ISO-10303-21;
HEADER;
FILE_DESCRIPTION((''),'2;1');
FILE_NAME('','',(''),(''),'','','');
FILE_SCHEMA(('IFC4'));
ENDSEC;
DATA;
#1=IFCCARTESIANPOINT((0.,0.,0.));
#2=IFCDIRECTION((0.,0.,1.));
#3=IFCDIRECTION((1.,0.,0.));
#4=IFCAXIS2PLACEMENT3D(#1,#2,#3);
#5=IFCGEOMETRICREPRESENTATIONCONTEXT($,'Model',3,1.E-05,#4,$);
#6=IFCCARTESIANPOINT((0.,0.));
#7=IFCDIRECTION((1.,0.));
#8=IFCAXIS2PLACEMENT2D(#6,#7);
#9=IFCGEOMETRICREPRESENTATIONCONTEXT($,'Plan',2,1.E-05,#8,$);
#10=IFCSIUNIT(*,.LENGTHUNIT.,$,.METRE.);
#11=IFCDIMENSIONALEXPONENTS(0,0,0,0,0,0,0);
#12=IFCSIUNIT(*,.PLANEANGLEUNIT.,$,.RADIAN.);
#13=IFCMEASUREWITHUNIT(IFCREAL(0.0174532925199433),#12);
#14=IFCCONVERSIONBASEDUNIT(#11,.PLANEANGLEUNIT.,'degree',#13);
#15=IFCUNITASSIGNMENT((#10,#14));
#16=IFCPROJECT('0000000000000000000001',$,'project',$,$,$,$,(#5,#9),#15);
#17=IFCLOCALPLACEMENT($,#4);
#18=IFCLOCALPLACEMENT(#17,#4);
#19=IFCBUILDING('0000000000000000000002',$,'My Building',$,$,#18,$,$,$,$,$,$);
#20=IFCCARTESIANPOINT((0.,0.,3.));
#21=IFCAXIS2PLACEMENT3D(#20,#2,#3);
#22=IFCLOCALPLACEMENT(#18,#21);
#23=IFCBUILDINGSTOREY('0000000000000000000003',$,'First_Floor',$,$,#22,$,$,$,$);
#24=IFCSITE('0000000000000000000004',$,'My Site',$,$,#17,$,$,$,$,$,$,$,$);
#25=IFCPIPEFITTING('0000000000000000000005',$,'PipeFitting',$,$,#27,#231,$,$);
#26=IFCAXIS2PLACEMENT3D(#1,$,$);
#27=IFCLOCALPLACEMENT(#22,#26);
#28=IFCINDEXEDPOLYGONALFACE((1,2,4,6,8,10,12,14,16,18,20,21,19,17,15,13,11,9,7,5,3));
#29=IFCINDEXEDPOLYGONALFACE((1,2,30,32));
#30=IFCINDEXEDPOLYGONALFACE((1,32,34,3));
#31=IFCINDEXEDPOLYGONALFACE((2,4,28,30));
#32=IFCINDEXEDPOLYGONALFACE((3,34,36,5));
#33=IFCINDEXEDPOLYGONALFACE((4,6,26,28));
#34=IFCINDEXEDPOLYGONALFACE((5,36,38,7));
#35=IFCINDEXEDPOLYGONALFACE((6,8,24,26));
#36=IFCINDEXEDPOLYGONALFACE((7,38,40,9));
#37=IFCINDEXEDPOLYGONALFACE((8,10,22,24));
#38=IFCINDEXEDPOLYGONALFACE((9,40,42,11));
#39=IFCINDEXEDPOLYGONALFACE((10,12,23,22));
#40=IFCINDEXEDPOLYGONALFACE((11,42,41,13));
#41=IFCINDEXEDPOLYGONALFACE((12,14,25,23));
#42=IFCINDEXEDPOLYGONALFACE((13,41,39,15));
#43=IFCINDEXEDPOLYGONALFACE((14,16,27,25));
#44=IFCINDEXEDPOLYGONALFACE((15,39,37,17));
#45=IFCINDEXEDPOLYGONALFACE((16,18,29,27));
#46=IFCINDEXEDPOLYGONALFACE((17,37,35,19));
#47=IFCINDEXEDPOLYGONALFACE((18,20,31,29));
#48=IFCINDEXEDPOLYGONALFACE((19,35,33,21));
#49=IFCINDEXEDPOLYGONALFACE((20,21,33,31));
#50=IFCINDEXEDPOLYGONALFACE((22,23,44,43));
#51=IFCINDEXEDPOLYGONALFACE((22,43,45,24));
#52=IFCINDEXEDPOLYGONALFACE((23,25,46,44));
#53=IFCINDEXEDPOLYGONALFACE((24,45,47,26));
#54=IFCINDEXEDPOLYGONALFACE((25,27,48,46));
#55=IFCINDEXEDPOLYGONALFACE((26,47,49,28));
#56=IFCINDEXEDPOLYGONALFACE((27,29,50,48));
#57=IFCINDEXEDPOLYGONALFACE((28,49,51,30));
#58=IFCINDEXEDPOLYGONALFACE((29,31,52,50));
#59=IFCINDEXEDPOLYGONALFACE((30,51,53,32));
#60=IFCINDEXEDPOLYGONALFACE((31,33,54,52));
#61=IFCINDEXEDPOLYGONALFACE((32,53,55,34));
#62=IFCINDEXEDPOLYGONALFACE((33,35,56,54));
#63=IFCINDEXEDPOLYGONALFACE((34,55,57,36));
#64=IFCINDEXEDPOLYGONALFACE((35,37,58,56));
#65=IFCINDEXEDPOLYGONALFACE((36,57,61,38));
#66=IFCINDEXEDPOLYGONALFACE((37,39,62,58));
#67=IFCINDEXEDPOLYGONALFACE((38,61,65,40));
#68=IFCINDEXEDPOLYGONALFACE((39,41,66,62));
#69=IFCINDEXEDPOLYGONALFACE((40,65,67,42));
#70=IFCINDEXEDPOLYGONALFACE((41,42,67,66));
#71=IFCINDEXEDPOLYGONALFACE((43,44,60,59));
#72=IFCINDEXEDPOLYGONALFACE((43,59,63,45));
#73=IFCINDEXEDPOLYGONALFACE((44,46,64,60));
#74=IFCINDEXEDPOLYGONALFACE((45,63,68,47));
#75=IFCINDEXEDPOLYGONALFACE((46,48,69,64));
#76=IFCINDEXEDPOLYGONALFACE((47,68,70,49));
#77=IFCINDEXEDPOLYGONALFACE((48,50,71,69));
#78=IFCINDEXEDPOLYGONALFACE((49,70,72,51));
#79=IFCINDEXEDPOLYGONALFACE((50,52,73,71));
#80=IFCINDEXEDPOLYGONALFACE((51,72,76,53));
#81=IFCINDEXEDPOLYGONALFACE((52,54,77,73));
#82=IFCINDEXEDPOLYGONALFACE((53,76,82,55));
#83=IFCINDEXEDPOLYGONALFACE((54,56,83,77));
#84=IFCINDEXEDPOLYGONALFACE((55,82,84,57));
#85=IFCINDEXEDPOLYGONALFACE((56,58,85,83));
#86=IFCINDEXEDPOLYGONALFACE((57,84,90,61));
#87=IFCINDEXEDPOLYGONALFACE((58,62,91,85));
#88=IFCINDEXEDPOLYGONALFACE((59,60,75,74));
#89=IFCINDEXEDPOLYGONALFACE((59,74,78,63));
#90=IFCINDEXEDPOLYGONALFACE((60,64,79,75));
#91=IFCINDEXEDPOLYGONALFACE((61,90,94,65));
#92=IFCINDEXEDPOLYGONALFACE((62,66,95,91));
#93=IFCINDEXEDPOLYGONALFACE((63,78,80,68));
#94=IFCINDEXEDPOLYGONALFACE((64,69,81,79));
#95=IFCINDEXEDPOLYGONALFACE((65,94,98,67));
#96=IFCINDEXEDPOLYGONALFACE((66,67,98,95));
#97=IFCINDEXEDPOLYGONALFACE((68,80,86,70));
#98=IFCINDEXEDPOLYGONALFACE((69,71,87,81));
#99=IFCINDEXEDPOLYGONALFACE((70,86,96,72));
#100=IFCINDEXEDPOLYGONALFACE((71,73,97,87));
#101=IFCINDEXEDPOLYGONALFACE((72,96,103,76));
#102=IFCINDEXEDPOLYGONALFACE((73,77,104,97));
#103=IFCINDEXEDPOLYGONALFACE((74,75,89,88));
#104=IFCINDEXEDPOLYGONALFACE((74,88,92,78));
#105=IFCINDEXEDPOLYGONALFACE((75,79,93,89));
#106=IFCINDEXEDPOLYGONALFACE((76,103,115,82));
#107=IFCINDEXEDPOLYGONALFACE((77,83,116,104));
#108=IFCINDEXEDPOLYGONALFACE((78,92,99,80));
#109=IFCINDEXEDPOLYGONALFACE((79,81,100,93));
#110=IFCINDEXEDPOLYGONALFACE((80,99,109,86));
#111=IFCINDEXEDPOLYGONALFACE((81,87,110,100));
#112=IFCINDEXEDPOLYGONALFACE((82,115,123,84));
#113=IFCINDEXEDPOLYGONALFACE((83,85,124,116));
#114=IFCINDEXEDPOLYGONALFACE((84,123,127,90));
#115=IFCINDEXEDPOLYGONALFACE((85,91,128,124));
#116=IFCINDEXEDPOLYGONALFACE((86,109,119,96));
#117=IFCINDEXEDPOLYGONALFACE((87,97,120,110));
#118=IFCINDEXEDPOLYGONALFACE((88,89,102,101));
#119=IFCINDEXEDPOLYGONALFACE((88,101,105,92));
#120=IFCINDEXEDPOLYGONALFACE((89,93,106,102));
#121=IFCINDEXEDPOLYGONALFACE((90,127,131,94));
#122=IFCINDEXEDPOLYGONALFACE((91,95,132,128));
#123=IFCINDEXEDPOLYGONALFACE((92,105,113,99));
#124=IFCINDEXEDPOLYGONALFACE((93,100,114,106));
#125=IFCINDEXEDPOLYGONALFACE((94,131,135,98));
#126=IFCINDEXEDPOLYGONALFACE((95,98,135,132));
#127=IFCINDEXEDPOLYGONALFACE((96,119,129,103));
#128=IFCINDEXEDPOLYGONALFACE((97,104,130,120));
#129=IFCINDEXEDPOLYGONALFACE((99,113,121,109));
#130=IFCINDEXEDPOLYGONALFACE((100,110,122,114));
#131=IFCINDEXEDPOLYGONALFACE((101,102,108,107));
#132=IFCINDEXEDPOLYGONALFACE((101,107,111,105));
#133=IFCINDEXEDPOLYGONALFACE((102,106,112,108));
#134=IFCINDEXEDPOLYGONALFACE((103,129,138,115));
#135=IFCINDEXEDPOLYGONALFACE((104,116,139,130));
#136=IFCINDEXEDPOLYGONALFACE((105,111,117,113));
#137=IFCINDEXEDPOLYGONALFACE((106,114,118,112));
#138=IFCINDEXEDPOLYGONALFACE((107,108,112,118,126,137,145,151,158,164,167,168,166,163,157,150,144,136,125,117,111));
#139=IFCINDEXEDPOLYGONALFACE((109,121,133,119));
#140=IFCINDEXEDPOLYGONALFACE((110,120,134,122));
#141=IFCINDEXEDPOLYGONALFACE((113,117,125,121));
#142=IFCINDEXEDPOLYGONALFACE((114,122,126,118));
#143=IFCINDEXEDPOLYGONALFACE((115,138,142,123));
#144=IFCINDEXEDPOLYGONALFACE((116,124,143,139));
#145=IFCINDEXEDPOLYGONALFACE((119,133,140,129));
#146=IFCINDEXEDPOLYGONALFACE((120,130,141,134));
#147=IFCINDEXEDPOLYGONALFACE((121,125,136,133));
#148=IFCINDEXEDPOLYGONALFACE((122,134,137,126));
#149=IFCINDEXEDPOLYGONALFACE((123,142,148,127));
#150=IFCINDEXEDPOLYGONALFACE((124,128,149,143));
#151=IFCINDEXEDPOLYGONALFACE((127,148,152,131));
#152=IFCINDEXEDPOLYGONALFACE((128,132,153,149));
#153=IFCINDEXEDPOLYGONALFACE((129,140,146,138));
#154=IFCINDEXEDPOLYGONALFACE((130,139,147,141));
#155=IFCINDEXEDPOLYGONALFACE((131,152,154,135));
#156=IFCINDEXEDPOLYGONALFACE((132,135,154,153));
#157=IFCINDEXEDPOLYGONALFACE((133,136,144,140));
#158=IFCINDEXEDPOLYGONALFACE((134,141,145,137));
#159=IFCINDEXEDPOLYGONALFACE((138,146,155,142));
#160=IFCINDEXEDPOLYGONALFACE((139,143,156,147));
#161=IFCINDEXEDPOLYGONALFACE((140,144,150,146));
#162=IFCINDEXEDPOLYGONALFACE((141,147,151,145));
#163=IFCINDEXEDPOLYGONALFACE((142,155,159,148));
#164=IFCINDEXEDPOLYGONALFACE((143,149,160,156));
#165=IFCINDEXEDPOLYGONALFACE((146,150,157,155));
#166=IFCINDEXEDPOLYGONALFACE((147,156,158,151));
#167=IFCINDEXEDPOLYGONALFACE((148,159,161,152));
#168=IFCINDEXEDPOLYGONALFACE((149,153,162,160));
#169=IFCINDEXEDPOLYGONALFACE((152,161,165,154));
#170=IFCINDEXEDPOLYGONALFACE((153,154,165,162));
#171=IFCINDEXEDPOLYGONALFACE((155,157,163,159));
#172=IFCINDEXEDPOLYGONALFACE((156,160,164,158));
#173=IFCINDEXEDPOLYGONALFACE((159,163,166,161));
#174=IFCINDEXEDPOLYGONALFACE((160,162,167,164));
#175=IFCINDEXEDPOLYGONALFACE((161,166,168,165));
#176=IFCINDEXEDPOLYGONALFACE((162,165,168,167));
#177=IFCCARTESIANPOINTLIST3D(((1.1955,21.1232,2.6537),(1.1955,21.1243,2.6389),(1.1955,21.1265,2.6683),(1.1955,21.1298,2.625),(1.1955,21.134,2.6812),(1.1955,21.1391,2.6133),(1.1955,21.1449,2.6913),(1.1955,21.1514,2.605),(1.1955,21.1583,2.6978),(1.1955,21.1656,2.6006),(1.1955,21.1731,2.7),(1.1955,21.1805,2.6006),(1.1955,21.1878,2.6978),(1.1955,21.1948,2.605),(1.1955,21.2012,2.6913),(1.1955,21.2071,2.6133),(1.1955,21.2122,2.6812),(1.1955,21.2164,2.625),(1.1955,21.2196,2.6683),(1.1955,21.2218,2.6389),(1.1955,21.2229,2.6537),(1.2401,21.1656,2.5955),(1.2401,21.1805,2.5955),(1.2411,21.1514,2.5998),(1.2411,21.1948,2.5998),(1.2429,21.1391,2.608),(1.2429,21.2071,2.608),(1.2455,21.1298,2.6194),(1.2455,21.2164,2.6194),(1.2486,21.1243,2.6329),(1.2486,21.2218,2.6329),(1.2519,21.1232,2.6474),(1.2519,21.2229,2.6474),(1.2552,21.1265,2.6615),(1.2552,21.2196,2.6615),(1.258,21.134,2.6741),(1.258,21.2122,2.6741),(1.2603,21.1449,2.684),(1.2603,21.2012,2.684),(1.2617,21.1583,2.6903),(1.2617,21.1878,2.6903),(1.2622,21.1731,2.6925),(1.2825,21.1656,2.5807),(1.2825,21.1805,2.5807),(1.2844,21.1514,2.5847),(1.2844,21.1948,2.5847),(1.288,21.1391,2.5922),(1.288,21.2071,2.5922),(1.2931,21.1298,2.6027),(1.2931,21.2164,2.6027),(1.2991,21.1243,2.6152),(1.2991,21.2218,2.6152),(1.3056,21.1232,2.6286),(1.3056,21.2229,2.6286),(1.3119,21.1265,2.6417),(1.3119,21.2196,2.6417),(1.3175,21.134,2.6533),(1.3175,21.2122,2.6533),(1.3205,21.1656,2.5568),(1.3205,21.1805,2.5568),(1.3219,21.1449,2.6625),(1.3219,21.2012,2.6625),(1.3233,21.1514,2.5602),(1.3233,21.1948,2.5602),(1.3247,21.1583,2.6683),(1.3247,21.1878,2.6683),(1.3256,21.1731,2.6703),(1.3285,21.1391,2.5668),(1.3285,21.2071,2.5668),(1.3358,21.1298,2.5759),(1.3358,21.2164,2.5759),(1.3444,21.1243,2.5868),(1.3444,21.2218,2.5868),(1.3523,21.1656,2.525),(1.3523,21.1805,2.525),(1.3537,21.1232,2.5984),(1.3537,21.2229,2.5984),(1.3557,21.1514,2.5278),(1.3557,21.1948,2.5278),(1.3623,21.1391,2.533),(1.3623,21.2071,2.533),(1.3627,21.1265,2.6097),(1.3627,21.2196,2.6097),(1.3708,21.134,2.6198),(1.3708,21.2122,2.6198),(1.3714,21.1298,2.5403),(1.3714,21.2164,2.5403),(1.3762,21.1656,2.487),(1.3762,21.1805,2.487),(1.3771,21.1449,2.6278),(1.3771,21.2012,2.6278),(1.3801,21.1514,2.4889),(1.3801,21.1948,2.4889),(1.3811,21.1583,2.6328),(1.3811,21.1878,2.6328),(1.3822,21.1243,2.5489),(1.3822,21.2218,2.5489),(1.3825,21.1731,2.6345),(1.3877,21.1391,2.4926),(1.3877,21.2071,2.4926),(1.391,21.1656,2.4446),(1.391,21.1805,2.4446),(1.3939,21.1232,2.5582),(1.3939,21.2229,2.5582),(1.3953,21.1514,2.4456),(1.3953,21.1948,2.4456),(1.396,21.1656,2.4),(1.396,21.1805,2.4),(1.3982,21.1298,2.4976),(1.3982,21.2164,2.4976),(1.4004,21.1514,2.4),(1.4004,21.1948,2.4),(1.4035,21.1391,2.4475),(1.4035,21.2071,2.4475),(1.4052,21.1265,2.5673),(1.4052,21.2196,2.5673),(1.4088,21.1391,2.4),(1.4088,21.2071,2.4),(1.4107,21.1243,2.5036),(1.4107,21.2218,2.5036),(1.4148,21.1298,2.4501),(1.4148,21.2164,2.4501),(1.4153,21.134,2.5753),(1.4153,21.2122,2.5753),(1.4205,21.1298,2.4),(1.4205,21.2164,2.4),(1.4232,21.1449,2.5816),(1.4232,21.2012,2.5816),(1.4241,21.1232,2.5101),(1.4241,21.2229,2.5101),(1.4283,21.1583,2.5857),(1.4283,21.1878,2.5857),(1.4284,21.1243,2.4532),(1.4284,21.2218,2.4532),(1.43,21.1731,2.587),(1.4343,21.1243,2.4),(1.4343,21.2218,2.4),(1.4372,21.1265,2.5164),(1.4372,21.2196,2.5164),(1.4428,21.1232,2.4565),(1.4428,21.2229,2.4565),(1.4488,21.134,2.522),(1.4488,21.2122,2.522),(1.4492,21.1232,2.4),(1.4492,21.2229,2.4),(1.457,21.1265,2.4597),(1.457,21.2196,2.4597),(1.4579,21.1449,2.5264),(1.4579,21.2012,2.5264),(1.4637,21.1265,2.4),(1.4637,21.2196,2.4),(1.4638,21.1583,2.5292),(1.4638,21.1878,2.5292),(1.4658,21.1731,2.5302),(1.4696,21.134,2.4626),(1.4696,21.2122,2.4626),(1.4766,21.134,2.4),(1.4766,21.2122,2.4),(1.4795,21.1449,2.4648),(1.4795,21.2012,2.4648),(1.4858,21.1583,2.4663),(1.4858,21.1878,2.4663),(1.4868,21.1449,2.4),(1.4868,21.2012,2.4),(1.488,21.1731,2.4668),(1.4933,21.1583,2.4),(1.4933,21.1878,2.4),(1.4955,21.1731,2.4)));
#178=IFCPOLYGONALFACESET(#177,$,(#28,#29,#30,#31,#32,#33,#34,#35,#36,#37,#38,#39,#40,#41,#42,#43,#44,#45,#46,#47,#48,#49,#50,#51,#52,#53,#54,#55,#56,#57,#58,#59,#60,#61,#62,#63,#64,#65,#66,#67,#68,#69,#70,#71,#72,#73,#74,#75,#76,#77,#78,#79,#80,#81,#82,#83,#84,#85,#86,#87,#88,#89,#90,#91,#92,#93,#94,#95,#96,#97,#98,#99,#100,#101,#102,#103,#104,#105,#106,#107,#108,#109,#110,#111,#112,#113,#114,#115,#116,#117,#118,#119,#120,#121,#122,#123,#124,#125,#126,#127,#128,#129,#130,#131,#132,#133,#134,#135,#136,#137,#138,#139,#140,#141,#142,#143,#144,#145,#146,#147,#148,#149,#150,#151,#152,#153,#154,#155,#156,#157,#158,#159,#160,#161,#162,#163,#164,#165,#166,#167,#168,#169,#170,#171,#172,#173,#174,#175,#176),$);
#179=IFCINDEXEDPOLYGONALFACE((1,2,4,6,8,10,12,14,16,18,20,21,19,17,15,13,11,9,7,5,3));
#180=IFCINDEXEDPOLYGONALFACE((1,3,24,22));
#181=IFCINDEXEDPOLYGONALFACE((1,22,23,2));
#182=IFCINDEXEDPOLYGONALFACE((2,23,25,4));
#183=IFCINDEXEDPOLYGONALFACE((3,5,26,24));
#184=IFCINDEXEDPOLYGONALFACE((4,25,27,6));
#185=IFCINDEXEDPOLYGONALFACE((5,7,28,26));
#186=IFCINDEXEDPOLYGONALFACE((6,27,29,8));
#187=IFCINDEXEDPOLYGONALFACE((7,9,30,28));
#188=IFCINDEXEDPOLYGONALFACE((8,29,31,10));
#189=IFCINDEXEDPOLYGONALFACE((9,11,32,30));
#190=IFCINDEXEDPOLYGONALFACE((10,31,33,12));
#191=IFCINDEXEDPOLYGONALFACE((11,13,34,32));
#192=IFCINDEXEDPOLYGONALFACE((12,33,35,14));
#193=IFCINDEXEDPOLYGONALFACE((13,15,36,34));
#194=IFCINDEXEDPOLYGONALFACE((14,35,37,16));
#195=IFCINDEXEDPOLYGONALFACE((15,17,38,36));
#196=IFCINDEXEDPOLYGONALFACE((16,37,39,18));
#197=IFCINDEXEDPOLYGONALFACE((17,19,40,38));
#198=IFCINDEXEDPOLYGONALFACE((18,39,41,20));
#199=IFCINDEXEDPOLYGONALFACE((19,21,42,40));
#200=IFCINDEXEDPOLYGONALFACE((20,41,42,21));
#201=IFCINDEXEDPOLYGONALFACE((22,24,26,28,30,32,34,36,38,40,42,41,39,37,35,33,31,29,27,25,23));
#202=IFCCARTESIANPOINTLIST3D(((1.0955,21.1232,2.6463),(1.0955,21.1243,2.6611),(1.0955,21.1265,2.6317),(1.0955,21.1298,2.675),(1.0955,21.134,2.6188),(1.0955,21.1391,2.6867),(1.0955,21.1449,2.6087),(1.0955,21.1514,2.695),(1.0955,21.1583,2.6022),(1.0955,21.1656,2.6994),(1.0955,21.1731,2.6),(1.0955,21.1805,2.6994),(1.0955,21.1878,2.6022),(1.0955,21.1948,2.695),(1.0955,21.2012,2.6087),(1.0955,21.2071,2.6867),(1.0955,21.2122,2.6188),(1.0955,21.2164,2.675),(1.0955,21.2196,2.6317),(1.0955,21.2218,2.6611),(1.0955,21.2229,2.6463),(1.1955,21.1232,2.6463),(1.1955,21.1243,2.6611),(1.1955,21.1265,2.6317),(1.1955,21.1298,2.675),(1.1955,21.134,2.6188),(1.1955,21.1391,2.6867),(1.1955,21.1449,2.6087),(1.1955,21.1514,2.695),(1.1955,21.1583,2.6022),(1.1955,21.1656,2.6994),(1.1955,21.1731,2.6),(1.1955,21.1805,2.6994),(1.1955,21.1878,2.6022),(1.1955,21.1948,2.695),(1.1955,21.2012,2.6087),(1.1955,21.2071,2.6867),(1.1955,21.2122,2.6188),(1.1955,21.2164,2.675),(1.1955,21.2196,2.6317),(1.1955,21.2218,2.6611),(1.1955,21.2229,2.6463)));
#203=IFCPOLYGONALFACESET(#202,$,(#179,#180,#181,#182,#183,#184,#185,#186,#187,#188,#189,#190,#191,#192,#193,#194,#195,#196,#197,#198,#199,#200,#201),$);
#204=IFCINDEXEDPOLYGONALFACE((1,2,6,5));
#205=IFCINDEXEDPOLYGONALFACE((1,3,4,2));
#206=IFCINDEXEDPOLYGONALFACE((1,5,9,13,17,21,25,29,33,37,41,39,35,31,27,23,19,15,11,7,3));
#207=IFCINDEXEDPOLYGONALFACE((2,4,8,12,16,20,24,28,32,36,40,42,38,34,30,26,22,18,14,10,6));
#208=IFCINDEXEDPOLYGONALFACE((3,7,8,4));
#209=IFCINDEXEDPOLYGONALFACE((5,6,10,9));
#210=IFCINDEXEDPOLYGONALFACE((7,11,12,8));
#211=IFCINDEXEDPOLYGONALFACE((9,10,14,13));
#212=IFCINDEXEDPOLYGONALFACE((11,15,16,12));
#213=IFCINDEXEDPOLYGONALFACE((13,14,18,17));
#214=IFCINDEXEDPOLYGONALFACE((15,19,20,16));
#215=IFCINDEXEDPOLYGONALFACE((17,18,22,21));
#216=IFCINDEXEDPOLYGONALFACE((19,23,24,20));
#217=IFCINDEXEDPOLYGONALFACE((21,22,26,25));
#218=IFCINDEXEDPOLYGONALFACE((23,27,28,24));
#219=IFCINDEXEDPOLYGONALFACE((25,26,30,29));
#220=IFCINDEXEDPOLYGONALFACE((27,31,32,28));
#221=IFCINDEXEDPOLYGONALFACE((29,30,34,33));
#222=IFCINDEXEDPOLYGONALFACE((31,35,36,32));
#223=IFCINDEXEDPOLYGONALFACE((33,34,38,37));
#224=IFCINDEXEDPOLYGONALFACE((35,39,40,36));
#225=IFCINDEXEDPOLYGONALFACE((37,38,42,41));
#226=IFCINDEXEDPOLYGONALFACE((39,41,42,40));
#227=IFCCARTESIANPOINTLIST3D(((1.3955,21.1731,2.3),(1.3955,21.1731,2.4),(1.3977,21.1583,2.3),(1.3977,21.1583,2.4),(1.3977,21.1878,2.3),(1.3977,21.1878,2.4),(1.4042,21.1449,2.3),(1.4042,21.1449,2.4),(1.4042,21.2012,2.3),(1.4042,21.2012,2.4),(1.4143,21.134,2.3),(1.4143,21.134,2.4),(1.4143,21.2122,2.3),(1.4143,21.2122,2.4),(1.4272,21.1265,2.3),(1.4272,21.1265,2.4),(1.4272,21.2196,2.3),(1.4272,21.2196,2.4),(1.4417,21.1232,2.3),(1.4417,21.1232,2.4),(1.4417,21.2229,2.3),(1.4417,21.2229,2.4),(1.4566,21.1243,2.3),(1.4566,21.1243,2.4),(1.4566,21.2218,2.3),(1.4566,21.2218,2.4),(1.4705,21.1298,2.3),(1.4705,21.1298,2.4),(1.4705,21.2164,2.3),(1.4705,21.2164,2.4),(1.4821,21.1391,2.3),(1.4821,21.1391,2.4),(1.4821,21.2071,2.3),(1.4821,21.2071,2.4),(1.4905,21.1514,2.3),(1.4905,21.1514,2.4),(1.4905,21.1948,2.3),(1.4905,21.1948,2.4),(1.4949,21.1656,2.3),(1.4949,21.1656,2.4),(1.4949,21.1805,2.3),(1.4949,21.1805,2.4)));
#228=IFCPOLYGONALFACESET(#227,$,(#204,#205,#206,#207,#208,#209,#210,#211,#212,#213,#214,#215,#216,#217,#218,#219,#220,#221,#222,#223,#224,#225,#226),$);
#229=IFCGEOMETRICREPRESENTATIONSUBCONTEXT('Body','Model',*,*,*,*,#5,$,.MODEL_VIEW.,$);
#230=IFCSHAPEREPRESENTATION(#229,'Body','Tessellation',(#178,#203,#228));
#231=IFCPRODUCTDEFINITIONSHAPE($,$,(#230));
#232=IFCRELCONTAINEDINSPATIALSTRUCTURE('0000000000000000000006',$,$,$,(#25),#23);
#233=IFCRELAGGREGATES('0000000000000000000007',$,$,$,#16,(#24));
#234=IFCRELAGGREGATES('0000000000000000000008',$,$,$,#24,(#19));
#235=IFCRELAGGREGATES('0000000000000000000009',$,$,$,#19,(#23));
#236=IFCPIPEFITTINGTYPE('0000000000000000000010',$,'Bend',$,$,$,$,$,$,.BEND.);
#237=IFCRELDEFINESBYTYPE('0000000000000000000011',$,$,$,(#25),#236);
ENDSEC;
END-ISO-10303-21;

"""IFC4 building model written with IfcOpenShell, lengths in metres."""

from ifc_helpers import new_model, entity, si_unit, converted_unit, frame, origin_with_axes, origin_2d_with_axis, place, context, subcontext, project, spatial, circle, extrude, source, transform, mapped, type_object, type_shapes, element, save


model = new_model("IFC4")

# Units and contexts
model_context = context("Model", 3, precision=1e-05, world=origin_with_axes())
plan_context = context("Plan", 2, precision=1e-05, world=origin_2d_with_axis())
body_context = subcontext(model_context, "Body", "Model", "MODEL_VIEW")
ifc_project = project(units=[si_unit("LENGTHUNIT", "METRE"), converted_unit("PLANEANGLEUNIT", "degree", entity("IfcReal", 0.0174532925199433), si_unit("PLANEANGLEUNIT", "RADIAN"), dimensions=[0, 0, 0, 0, 0, 0, 0])], contexts=[model_context, plan_context])

# Site, building, storey
site_placement = place(None, origin_with_axes())
site = spatial("IfcSite", under=ifc_project, at=site_placement, Name="My Site")
building_placement = place(site_placement, origin_with_axes())
building = spatial("IfcBuilding", under=site, at=building_placement, Name="My Building")
storey_placement = place(building_placement, frame((0.0, 0.0, 3.0), z_axis=(0.0, 0.0, 1.0), x_axis=(1.0, 0.0, 0.0)))
storey = spatial("IfcBuildingStorey", under=building, at=storey_placement, Name="First_Floor")

# Pipe fitting
pipe_fitting_type = type_object("IfcPipeFittingType", Name="Bend", PredefinedType="BEND")
shared_shape = source(origin_with_axes(), body_context, "Body", "SolidModel", [
    entity("IfcSweptDiskSolid", entity("IfcIndexedPolyCurve", entity("IfcCartesianPointList3D", [[0.0, 0.0, -0.1], [0.0732, 0.0, -0.2768], [0.25, 0.0, -0.35]]), [entity("IfcArcIndex", [1, 2, 3])]), 0.05),
    extrude(circle(Radius=0.05), origin_with_axes(), (0.0, 0.0, -1.0), 0.1),
    extrude(circle(Radius=0.05), frame((0.25, 0.0, -0.35), z_axis=(1.0, 0.0, 0.0), x_axis=(0.0, 0.0, 1.0)), (0.0, 0.0, 1.0), 0.1),
])
type_shapes(pipe_fitting_type, [shared_shape])
for number, where, z_axis, x_axis, name in (
    (1, (1.0955, 21.1731, 2.65), (-1.0, 0.0, 0.0), (0.0, 0.0, -1.0), "PipeFitting"),
):
    element("IfcPipeFitting", number, at=place(storey_placement, frame(where, z_axis=z_axis, x_axis=x_axis)), inside=storey, type_object=pipe_fitting_type, Name=name, context=body_context, shape_type="MappedRepresentation", body=[
        mapped(shared_shape, transform((0.0, 0.0, 0.0), x_axis=(1.0, 0.0, 0.0), y_axis=(0.0, 1.0, 0.0), z_axis=(0.0, 0.0, 1.0), scale=1.0)),
    ])

save(model, "model.ifc")
